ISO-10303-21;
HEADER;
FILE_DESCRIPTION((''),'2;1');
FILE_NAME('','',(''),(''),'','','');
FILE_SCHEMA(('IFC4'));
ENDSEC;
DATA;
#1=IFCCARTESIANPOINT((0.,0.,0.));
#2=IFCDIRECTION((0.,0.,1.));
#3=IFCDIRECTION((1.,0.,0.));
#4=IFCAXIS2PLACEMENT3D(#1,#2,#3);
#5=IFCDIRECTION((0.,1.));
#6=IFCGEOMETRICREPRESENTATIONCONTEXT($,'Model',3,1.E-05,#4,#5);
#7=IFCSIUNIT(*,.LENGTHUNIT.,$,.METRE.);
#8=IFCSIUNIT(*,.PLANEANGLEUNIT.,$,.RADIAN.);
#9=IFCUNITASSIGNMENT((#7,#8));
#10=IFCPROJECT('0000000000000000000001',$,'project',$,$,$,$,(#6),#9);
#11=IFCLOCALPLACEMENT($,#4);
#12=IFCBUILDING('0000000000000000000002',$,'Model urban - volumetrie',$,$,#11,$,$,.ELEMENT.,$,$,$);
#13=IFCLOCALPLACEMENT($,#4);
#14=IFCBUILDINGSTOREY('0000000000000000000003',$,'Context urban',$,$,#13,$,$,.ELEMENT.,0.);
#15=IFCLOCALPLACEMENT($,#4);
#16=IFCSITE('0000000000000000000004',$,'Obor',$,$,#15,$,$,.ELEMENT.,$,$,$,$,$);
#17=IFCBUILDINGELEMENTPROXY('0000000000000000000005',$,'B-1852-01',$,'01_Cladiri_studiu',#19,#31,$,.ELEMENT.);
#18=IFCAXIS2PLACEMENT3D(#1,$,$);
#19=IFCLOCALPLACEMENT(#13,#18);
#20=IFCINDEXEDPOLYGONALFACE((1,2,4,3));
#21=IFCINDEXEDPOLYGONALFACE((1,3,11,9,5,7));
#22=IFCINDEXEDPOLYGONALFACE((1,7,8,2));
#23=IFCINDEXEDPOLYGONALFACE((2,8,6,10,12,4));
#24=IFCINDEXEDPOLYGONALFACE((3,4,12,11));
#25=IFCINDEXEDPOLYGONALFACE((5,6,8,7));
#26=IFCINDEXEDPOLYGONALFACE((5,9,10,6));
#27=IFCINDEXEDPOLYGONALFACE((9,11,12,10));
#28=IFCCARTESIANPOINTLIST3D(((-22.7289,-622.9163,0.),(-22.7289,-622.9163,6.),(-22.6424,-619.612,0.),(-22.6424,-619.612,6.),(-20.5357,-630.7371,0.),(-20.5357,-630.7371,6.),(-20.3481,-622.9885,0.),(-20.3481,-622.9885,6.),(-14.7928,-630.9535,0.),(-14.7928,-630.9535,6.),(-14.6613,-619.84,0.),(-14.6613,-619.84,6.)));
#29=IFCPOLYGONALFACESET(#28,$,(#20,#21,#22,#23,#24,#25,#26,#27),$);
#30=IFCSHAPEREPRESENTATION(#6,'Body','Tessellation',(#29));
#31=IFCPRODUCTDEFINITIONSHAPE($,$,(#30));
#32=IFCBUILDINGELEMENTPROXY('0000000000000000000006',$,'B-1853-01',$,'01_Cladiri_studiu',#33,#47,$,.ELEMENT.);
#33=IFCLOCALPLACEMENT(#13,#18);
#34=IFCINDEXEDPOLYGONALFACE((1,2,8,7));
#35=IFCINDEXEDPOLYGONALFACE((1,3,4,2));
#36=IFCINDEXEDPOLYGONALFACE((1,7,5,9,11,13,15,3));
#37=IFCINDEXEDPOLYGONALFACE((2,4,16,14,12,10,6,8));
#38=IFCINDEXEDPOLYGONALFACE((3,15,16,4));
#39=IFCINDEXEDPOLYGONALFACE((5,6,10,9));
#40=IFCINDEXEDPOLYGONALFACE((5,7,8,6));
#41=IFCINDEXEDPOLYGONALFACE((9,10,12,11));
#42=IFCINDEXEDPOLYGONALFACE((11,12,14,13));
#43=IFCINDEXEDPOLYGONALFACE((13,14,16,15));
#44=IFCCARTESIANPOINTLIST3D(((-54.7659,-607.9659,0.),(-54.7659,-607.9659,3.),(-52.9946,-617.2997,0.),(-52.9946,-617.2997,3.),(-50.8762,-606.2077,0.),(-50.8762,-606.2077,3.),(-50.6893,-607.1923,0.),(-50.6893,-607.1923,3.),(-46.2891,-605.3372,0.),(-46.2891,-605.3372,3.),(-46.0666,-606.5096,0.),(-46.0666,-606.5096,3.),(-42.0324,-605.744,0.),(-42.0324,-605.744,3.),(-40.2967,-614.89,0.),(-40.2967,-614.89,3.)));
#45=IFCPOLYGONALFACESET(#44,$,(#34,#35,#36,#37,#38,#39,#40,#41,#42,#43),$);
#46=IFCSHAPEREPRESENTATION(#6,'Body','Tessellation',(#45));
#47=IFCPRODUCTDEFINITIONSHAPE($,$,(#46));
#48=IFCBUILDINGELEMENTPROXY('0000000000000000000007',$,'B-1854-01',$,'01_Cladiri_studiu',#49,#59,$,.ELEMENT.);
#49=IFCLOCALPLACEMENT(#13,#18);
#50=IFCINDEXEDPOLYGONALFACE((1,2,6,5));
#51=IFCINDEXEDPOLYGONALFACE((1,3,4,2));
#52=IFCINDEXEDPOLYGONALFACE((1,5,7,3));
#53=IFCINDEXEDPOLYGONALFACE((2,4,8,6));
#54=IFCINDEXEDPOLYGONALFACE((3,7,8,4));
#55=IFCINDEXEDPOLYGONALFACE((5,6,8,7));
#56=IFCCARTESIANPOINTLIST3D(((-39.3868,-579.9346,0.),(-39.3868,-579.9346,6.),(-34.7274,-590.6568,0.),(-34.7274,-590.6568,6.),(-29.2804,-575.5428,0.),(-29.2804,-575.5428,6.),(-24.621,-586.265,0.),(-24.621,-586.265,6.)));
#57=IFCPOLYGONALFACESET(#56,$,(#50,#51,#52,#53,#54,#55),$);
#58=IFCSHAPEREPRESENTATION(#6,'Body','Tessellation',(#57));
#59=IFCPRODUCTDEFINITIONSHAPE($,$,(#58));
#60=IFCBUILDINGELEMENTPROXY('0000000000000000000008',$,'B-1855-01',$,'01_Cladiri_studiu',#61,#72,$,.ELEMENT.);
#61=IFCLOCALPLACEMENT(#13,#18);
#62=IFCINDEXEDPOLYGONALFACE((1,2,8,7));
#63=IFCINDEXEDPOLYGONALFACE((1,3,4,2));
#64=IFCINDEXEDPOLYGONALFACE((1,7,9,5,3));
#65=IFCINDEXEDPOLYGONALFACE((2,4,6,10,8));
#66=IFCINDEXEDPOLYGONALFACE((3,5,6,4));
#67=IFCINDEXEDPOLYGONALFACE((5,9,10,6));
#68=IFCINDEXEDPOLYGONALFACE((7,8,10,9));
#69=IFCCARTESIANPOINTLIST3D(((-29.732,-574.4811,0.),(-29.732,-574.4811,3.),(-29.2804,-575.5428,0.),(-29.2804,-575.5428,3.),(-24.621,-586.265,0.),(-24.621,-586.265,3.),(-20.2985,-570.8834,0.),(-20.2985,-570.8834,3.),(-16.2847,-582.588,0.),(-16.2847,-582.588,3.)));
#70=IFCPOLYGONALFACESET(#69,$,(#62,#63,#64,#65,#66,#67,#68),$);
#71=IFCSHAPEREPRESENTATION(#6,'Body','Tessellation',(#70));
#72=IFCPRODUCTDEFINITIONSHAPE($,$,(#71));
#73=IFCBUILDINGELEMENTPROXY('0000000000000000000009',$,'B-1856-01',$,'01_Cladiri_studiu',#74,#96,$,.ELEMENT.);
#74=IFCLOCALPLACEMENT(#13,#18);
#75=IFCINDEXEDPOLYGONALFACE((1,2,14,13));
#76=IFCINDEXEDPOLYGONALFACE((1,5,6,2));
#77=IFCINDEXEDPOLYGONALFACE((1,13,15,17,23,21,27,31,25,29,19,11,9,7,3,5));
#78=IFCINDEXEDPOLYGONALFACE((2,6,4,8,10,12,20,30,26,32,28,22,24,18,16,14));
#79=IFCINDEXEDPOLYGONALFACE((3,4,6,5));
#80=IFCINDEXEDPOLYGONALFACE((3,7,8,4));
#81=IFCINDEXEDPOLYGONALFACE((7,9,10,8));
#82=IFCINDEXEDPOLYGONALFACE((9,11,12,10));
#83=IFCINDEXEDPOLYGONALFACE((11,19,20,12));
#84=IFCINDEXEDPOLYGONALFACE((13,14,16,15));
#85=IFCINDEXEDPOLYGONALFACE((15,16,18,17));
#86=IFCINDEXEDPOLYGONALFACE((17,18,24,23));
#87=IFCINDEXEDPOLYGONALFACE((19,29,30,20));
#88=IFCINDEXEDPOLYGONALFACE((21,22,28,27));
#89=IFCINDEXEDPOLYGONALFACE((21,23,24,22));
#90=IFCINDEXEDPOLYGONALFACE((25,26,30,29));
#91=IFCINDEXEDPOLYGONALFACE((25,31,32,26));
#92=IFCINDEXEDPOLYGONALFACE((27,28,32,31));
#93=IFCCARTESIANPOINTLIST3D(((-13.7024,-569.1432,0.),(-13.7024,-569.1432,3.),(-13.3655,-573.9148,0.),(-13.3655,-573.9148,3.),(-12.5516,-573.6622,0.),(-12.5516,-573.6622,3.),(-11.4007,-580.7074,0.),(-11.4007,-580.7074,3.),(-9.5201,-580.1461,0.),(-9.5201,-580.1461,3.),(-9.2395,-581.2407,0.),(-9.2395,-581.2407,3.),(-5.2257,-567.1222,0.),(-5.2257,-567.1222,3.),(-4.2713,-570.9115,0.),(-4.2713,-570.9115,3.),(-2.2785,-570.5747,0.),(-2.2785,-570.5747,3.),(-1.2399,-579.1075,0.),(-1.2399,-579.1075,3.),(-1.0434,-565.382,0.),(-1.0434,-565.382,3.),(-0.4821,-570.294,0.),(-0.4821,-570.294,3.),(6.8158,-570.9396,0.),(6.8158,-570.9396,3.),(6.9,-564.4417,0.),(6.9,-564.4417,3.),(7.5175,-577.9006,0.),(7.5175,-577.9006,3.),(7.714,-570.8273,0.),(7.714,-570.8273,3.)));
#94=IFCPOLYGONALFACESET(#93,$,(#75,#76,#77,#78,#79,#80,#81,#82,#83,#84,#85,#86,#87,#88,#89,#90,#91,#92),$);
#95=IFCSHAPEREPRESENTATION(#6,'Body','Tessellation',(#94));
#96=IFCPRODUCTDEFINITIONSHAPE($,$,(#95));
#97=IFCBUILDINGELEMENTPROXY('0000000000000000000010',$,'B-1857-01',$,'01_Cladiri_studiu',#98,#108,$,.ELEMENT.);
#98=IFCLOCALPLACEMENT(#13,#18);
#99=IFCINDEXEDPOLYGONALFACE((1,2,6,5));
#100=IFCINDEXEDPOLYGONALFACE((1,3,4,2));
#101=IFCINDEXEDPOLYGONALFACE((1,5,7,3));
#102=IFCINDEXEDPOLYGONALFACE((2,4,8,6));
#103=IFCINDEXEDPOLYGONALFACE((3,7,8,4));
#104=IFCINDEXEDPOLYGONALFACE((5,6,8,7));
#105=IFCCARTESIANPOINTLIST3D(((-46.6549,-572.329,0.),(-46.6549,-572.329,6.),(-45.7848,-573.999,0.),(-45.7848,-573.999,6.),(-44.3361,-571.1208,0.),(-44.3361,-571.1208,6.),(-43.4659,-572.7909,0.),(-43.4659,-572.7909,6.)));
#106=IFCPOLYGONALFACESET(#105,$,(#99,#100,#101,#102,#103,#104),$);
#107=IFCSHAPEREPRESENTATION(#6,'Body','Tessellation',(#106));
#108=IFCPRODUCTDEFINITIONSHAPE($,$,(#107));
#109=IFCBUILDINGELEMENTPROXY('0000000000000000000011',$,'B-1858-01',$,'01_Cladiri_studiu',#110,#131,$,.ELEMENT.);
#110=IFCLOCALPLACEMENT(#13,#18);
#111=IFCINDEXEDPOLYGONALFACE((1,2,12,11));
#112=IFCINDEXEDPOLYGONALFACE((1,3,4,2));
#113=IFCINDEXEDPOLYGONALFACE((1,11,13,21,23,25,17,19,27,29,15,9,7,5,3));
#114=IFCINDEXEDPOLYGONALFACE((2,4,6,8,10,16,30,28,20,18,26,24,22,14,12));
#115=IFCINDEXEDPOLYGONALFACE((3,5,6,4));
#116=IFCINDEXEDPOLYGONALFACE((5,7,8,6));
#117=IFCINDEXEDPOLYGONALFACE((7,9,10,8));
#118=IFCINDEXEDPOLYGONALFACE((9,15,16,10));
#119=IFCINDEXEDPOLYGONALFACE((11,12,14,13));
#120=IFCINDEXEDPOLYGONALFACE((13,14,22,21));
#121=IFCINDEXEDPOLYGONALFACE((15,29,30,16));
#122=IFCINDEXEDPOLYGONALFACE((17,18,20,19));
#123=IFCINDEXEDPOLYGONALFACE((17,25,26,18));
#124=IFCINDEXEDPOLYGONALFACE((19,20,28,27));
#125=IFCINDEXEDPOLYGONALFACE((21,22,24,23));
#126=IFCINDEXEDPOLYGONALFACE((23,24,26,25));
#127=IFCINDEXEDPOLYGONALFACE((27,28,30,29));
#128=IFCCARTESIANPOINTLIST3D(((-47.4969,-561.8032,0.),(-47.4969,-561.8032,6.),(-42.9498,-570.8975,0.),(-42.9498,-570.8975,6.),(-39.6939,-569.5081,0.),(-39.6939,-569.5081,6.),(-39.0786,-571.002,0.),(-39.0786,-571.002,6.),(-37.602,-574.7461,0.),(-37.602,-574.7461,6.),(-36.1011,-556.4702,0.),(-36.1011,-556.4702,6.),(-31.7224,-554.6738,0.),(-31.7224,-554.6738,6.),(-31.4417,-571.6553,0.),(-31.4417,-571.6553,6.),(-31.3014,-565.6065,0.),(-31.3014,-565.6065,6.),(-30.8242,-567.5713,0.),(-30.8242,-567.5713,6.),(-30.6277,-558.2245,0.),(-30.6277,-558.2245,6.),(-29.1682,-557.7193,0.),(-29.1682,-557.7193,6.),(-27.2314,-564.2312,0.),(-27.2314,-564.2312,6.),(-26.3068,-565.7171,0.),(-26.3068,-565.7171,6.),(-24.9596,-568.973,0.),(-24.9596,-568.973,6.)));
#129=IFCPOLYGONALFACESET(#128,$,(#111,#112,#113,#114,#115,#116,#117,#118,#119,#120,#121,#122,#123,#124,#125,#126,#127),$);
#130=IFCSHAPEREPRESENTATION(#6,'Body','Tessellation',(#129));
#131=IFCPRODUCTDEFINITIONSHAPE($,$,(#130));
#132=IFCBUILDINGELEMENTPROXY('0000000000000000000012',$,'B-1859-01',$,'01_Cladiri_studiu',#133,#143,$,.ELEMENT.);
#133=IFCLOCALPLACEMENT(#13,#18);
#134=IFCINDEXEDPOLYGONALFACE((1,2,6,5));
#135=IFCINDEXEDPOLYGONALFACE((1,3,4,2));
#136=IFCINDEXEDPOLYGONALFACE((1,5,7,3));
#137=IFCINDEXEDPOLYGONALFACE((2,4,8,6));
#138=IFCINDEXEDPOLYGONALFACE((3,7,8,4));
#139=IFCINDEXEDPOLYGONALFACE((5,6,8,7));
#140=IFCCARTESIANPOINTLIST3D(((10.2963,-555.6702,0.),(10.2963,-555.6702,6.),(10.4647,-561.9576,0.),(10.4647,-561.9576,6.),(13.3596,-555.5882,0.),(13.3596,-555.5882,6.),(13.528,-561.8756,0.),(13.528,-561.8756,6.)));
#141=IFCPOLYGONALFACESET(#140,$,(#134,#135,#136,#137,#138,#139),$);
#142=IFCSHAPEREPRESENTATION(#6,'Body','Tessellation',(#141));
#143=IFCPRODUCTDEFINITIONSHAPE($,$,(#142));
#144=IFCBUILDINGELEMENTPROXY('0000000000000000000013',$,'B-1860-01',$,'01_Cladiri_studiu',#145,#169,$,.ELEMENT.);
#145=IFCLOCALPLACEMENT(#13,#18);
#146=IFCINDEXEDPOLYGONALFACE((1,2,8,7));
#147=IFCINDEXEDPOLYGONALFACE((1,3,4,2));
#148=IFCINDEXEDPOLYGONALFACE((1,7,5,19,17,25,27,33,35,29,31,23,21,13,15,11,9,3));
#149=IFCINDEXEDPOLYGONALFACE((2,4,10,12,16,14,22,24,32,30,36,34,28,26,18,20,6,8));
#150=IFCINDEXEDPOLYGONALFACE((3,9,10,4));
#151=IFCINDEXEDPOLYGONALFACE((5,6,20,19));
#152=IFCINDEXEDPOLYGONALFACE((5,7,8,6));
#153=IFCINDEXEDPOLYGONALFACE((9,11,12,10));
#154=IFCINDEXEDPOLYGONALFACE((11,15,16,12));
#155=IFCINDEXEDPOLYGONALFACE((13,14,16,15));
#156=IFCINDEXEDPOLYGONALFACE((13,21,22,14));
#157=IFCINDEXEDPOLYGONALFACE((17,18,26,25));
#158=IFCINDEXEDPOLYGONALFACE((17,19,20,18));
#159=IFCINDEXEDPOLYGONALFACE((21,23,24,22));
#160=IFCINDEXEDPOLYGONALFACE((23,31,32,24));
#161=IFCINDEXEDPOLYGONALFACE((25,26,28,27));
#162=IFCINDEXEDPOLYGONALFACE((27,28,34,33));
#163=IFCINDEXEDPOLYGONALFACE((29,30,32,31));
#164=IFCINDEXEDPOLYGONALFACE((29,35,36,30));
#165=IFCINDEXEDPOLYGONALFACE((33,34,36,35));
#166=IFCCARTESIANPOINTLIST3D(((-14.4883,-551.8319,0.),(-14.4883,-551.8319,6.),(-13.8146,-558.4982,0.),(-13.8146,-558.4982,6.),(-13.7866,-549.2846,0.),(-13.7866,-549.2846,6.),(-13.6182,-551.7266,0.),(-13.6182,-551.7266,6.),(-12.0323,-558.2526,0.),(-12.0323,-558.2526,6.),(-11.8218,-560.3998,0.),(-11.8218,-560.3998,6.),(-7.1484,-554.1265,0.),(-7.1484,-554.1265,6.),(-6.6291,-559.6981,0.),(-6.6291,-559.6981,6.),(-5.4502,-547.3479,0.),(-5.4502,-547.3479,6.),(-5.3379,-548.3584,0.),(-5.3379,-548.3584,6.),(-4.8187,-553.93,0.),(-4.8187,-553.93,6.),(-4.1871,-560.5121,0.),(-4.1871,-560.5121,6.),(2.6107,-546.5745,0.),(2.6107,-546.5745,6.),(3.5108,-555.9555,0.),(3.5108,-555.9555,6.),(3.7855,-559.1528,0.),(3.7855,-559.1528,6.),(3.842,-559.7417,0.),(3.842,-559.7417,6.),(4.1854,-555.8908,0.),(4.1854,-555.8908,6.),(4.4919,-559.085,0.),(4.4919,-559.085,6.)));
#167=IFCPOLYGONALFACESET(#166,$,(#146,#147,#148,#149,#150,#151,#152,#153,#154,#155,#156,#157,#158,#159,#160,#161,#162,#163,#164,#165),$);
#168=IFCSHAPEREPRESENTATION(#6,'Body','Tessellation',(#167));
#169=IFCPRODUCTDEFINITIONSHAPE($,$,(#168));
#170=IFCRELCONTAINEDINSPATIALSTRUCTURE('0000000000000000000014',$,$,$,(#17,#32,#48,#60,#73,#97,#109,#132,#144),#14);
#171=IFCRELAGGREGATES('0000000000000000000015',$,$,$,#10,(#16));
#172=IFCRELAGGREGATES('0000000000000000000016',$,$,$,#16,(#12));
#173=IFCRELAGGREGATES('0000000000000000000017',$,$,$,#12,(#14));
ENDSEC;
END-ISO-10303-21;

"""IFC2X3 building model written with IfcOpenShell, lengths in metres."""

from ifc_helpers import new_model, si_unit, direction, origin_with_axes, place, context, project, spatial, polyline, outline, extrude, element, save


model = new_model("IFC2X3")

# Units and contexts
model_context = context("Model", 3, precision=1e-05, world=origin_with_axes(), true_north=direction((0.0, 1.0)))
ifc_project = project(units=[si_unit("LENGTHUNIT", "METRE"), si_unit("PLANEANGLEUNIT", "RADIAN")], contexts=[model_context])

# Site, building, storey
site_placement = place(None, origin_with_axes())
site = spatial("IfcSite", under=ifc_project, at=site_placement, Name="Obor", CompositionType="ELEMENT")
building_placement = place(None, origin_with_axes())
building = spatial("IfcBuilding", under=site, at=building_placement, Name="Model urban - volumetrie", CompositionType="ELEMENT")
storey_placement = place(None, origin_with_axes())
storey = spatial("IfcBuildingStorey", under=building, at=storey_placement, Name="Context urban", CompositionType="ELEMENT", Elevation=0.0)

# Building element proxies
proxy_1_placement = place(None, origin_with_axes())
element("IfcBuildingElementProxy", 1, at=proxy_1_placement, inside=storey, Name="B-1852-01", ObjectType="01_Cladiri_studiu", CompositionType="ELEMENT", context=model_context, shape_type="SweptSolid", body=[
    extrude(outline(polyline([(-20.5357, -630.7371), (-14.7928, -630.9535), (-14.6613, -619.84), (-22.6424, -619.612), (-22.7289, -622.9163), (-20.3481, -622.9885), (-20.5357, -630.7371)])), origin_with_axes(), (0.0, 0.0, 1.0), 6.0),
])
proxy_2_placement = place(None, origin_with_axes())
element("IfcBuildingElementProxy", 2, at=proxy_2_placement, inside=storey, Name="B-1853-01", ObjectType="01_Cladiri_studiu", CompositionType="ELEMENT", context=model_context, shape_type="SweptSolid", body=[
    extrude(outline(polyline([(-40.2967, -614.89), (-42.0324, -605.744), (-46.0666, -606.5096), (-46.2891, -605.3372), (-50.8762, -606.2077), (-50.6893, -607.1923), (-54.7659, -607.9659), (-52.9946, -617.2997), (-40.2967, -614.89)])), origin_with_axes(), (0.0, 0.0, 1.0), 3.0),
])
proxy_3_placement = place(None, origin_with_axes())
element("IfcBuildingElementProxy", 3, at=proxy_3_placement, inside=storey, Name="B-1854-01", ObjectType="01_Cladiri_studiu", CompositionType="ELEMENT", context=model_context, shape_type="SweptSolid", body=[
    extrude(outline(polyline([(-34.7274, -590.6568), (-24.621, -586.265), (-29.2804, -575.5428), (-39.3868, -579.9346), (-34.7274, -590.6568)])), origin_with_axes(), (0.0, 0.0, 1.0), 6.0),
])
proxy_4_placement = place(None, origin_with_axes())
element("IfcBuildingElementProxy", 4, at=proxy_4_placement, inside=storey, Name="B-1855-01", ObjectType="01_Cladiri_studiu", CompositionType="ELEMENT", context=model_context, shape_type="SweptSolid", body=[
    extrude(outline(polyline([(-24.621, -586.265), (-16.2847, -582.588), (-20.2985, -570.8834), (-29.732, -574.4811), (-29.2804, -575.5428), (-24.621, -586.265)])), origin_with_axes(), (0.0, 0.0, 1.0), 3.0),
])
proxy_5_placement = place(None, origin_with_axes())
element("IfcBuildingElementProxy", 5, at=proxy_5_placement, inside=storey, Name="B-1856-01", ObjectType="01_Cladiri_studiu", CompositionType="ELEMENT", context=model_context, shape_type="SweptSolid", body=[
    extrude(outline(polyline([(6.8158, -570.9396), (7.714, -570.8273), (6.9, -564.4417), (-1.0434, -565.382), (-0.4821, -570.294), (-2.2785, -570.5747), (-4.2713, -570.9115), (-5.2257, -567.1222), (-13.7024, -569.1432), (-12.5516, -573.6622), (-13.3655, -573.9148), (-11.4007, -580.7074), (-9.5201, -580.1461), (-9.2395, -581.2407), (-1.2399, -579.1075), (7.5175, -577.9006), (6.8158, -570.9396)])), origin_with_axes(), (0.0, 0.0, 1.0), 3.0),
])
proxy_6_placement = place(None, origin_with_axes())
element("IfcBuildingElementProxy", 6, at=proxy_6_placement, inside=storey, Name="B-1857-01", ObjectType="01_Cladiri_studiu", CompositionType="ELEMENT", context=model_context, shape_type="SweptSolid", body=[
    extrude(outline(polyline([(-45.7848, -573.999), (-43.4659, -572.7909), (-44.3361, -571.1208), (-46.6549, -572.329), (-45.7848, -573.999)])), origin_with_axes(), (0.0, 0.0, 1.0), 6.0),
])
proxy_7_placement = place(None, origin_with_axes())
element("IfcBuildingElementProxy", 7, at=proxy_7_placement, inside=storey, Name="B-1858-01", ObjectType="01_Cladiri_studiu", CompositionType="ELEMENT", context=model_context, shape_type="SweptSolid", body=[
    extrude(outline(polyline([(-24.9596, -568.973), (-26.3068, -565.7171), (-30.8242, -567.5713), (-31.3014, -565.6065), (-27.2314, -564.2312), (-29.1682, -557.7193), (-30.6277, -558.2245), (-31.7224, -554.6738), (-36.1011, -556.4702), (-47.4969, -561.8032), (-42.9498, -570.8975), (-39.6939, -569.5081), (-39.0786, -571.002), (-37.602, -574.7461), (-31.4417, -571.6553), (-24.9596, -568.973)])), origin_with_axes(), (0.0, 0.0, 1.0), 6.0),
])
proxy_8_placement = place(None, origin_with_axes())
element("IfcBuildingElementProxy", 8, at=proxy_8_placement, inside=storey, Name="B-1859-01", ObjectType="01_Cladiri_studiu", CompositionType="ELEMENT", context=model_context, shape_type="SweptSolid", body=[
    extrude(outline(polyline([(10.4647, -561.9576), (13.528, -561.8756), (13.3596, -555.5882), (10.2963, -555.6702), (10.4647, -561.9576)])), origin_with_axes(), (0.0, 0.0, 1.0), 6.0),
])
proxy_9_placement = place(None, origin_with_axes())
element("IfcBuildingElementProxy", 9, at=proxy_9_placement, inside=storey, Name="B-1860-01", ObjectType="01_Cladiri_studiu", CompositionType="ELEMENT", context=model_context, shape_type="SweptSolid", body=[
    extrude(outline(polyline([(4.4919, -559.085), (4.1854, -555.8908), (3.5108, -555.9555), (2.6107, -546.5745), (-5.4502, -547.3479), (-5.3379, -548.3584), (-13.7866, -549.2846), (-13.6182, -551.7266), (-14.4883, -551.8319), (-13.8146, -558.4982), (-12.0323, -558.2526), (-11.8218, -560.3998), (-6.6291, -559.6981), (-7.1484, -554.1265), (-4.8187, -553.93), (-4.1871, -560.5121), (3.842, -559.7417), (3.7855, -559.1528), (4.4919, -559.085)])), origin_with_axes(), (0.0, 0.0, 1.0), 6.0),
])

save(model, "model.ifc")
